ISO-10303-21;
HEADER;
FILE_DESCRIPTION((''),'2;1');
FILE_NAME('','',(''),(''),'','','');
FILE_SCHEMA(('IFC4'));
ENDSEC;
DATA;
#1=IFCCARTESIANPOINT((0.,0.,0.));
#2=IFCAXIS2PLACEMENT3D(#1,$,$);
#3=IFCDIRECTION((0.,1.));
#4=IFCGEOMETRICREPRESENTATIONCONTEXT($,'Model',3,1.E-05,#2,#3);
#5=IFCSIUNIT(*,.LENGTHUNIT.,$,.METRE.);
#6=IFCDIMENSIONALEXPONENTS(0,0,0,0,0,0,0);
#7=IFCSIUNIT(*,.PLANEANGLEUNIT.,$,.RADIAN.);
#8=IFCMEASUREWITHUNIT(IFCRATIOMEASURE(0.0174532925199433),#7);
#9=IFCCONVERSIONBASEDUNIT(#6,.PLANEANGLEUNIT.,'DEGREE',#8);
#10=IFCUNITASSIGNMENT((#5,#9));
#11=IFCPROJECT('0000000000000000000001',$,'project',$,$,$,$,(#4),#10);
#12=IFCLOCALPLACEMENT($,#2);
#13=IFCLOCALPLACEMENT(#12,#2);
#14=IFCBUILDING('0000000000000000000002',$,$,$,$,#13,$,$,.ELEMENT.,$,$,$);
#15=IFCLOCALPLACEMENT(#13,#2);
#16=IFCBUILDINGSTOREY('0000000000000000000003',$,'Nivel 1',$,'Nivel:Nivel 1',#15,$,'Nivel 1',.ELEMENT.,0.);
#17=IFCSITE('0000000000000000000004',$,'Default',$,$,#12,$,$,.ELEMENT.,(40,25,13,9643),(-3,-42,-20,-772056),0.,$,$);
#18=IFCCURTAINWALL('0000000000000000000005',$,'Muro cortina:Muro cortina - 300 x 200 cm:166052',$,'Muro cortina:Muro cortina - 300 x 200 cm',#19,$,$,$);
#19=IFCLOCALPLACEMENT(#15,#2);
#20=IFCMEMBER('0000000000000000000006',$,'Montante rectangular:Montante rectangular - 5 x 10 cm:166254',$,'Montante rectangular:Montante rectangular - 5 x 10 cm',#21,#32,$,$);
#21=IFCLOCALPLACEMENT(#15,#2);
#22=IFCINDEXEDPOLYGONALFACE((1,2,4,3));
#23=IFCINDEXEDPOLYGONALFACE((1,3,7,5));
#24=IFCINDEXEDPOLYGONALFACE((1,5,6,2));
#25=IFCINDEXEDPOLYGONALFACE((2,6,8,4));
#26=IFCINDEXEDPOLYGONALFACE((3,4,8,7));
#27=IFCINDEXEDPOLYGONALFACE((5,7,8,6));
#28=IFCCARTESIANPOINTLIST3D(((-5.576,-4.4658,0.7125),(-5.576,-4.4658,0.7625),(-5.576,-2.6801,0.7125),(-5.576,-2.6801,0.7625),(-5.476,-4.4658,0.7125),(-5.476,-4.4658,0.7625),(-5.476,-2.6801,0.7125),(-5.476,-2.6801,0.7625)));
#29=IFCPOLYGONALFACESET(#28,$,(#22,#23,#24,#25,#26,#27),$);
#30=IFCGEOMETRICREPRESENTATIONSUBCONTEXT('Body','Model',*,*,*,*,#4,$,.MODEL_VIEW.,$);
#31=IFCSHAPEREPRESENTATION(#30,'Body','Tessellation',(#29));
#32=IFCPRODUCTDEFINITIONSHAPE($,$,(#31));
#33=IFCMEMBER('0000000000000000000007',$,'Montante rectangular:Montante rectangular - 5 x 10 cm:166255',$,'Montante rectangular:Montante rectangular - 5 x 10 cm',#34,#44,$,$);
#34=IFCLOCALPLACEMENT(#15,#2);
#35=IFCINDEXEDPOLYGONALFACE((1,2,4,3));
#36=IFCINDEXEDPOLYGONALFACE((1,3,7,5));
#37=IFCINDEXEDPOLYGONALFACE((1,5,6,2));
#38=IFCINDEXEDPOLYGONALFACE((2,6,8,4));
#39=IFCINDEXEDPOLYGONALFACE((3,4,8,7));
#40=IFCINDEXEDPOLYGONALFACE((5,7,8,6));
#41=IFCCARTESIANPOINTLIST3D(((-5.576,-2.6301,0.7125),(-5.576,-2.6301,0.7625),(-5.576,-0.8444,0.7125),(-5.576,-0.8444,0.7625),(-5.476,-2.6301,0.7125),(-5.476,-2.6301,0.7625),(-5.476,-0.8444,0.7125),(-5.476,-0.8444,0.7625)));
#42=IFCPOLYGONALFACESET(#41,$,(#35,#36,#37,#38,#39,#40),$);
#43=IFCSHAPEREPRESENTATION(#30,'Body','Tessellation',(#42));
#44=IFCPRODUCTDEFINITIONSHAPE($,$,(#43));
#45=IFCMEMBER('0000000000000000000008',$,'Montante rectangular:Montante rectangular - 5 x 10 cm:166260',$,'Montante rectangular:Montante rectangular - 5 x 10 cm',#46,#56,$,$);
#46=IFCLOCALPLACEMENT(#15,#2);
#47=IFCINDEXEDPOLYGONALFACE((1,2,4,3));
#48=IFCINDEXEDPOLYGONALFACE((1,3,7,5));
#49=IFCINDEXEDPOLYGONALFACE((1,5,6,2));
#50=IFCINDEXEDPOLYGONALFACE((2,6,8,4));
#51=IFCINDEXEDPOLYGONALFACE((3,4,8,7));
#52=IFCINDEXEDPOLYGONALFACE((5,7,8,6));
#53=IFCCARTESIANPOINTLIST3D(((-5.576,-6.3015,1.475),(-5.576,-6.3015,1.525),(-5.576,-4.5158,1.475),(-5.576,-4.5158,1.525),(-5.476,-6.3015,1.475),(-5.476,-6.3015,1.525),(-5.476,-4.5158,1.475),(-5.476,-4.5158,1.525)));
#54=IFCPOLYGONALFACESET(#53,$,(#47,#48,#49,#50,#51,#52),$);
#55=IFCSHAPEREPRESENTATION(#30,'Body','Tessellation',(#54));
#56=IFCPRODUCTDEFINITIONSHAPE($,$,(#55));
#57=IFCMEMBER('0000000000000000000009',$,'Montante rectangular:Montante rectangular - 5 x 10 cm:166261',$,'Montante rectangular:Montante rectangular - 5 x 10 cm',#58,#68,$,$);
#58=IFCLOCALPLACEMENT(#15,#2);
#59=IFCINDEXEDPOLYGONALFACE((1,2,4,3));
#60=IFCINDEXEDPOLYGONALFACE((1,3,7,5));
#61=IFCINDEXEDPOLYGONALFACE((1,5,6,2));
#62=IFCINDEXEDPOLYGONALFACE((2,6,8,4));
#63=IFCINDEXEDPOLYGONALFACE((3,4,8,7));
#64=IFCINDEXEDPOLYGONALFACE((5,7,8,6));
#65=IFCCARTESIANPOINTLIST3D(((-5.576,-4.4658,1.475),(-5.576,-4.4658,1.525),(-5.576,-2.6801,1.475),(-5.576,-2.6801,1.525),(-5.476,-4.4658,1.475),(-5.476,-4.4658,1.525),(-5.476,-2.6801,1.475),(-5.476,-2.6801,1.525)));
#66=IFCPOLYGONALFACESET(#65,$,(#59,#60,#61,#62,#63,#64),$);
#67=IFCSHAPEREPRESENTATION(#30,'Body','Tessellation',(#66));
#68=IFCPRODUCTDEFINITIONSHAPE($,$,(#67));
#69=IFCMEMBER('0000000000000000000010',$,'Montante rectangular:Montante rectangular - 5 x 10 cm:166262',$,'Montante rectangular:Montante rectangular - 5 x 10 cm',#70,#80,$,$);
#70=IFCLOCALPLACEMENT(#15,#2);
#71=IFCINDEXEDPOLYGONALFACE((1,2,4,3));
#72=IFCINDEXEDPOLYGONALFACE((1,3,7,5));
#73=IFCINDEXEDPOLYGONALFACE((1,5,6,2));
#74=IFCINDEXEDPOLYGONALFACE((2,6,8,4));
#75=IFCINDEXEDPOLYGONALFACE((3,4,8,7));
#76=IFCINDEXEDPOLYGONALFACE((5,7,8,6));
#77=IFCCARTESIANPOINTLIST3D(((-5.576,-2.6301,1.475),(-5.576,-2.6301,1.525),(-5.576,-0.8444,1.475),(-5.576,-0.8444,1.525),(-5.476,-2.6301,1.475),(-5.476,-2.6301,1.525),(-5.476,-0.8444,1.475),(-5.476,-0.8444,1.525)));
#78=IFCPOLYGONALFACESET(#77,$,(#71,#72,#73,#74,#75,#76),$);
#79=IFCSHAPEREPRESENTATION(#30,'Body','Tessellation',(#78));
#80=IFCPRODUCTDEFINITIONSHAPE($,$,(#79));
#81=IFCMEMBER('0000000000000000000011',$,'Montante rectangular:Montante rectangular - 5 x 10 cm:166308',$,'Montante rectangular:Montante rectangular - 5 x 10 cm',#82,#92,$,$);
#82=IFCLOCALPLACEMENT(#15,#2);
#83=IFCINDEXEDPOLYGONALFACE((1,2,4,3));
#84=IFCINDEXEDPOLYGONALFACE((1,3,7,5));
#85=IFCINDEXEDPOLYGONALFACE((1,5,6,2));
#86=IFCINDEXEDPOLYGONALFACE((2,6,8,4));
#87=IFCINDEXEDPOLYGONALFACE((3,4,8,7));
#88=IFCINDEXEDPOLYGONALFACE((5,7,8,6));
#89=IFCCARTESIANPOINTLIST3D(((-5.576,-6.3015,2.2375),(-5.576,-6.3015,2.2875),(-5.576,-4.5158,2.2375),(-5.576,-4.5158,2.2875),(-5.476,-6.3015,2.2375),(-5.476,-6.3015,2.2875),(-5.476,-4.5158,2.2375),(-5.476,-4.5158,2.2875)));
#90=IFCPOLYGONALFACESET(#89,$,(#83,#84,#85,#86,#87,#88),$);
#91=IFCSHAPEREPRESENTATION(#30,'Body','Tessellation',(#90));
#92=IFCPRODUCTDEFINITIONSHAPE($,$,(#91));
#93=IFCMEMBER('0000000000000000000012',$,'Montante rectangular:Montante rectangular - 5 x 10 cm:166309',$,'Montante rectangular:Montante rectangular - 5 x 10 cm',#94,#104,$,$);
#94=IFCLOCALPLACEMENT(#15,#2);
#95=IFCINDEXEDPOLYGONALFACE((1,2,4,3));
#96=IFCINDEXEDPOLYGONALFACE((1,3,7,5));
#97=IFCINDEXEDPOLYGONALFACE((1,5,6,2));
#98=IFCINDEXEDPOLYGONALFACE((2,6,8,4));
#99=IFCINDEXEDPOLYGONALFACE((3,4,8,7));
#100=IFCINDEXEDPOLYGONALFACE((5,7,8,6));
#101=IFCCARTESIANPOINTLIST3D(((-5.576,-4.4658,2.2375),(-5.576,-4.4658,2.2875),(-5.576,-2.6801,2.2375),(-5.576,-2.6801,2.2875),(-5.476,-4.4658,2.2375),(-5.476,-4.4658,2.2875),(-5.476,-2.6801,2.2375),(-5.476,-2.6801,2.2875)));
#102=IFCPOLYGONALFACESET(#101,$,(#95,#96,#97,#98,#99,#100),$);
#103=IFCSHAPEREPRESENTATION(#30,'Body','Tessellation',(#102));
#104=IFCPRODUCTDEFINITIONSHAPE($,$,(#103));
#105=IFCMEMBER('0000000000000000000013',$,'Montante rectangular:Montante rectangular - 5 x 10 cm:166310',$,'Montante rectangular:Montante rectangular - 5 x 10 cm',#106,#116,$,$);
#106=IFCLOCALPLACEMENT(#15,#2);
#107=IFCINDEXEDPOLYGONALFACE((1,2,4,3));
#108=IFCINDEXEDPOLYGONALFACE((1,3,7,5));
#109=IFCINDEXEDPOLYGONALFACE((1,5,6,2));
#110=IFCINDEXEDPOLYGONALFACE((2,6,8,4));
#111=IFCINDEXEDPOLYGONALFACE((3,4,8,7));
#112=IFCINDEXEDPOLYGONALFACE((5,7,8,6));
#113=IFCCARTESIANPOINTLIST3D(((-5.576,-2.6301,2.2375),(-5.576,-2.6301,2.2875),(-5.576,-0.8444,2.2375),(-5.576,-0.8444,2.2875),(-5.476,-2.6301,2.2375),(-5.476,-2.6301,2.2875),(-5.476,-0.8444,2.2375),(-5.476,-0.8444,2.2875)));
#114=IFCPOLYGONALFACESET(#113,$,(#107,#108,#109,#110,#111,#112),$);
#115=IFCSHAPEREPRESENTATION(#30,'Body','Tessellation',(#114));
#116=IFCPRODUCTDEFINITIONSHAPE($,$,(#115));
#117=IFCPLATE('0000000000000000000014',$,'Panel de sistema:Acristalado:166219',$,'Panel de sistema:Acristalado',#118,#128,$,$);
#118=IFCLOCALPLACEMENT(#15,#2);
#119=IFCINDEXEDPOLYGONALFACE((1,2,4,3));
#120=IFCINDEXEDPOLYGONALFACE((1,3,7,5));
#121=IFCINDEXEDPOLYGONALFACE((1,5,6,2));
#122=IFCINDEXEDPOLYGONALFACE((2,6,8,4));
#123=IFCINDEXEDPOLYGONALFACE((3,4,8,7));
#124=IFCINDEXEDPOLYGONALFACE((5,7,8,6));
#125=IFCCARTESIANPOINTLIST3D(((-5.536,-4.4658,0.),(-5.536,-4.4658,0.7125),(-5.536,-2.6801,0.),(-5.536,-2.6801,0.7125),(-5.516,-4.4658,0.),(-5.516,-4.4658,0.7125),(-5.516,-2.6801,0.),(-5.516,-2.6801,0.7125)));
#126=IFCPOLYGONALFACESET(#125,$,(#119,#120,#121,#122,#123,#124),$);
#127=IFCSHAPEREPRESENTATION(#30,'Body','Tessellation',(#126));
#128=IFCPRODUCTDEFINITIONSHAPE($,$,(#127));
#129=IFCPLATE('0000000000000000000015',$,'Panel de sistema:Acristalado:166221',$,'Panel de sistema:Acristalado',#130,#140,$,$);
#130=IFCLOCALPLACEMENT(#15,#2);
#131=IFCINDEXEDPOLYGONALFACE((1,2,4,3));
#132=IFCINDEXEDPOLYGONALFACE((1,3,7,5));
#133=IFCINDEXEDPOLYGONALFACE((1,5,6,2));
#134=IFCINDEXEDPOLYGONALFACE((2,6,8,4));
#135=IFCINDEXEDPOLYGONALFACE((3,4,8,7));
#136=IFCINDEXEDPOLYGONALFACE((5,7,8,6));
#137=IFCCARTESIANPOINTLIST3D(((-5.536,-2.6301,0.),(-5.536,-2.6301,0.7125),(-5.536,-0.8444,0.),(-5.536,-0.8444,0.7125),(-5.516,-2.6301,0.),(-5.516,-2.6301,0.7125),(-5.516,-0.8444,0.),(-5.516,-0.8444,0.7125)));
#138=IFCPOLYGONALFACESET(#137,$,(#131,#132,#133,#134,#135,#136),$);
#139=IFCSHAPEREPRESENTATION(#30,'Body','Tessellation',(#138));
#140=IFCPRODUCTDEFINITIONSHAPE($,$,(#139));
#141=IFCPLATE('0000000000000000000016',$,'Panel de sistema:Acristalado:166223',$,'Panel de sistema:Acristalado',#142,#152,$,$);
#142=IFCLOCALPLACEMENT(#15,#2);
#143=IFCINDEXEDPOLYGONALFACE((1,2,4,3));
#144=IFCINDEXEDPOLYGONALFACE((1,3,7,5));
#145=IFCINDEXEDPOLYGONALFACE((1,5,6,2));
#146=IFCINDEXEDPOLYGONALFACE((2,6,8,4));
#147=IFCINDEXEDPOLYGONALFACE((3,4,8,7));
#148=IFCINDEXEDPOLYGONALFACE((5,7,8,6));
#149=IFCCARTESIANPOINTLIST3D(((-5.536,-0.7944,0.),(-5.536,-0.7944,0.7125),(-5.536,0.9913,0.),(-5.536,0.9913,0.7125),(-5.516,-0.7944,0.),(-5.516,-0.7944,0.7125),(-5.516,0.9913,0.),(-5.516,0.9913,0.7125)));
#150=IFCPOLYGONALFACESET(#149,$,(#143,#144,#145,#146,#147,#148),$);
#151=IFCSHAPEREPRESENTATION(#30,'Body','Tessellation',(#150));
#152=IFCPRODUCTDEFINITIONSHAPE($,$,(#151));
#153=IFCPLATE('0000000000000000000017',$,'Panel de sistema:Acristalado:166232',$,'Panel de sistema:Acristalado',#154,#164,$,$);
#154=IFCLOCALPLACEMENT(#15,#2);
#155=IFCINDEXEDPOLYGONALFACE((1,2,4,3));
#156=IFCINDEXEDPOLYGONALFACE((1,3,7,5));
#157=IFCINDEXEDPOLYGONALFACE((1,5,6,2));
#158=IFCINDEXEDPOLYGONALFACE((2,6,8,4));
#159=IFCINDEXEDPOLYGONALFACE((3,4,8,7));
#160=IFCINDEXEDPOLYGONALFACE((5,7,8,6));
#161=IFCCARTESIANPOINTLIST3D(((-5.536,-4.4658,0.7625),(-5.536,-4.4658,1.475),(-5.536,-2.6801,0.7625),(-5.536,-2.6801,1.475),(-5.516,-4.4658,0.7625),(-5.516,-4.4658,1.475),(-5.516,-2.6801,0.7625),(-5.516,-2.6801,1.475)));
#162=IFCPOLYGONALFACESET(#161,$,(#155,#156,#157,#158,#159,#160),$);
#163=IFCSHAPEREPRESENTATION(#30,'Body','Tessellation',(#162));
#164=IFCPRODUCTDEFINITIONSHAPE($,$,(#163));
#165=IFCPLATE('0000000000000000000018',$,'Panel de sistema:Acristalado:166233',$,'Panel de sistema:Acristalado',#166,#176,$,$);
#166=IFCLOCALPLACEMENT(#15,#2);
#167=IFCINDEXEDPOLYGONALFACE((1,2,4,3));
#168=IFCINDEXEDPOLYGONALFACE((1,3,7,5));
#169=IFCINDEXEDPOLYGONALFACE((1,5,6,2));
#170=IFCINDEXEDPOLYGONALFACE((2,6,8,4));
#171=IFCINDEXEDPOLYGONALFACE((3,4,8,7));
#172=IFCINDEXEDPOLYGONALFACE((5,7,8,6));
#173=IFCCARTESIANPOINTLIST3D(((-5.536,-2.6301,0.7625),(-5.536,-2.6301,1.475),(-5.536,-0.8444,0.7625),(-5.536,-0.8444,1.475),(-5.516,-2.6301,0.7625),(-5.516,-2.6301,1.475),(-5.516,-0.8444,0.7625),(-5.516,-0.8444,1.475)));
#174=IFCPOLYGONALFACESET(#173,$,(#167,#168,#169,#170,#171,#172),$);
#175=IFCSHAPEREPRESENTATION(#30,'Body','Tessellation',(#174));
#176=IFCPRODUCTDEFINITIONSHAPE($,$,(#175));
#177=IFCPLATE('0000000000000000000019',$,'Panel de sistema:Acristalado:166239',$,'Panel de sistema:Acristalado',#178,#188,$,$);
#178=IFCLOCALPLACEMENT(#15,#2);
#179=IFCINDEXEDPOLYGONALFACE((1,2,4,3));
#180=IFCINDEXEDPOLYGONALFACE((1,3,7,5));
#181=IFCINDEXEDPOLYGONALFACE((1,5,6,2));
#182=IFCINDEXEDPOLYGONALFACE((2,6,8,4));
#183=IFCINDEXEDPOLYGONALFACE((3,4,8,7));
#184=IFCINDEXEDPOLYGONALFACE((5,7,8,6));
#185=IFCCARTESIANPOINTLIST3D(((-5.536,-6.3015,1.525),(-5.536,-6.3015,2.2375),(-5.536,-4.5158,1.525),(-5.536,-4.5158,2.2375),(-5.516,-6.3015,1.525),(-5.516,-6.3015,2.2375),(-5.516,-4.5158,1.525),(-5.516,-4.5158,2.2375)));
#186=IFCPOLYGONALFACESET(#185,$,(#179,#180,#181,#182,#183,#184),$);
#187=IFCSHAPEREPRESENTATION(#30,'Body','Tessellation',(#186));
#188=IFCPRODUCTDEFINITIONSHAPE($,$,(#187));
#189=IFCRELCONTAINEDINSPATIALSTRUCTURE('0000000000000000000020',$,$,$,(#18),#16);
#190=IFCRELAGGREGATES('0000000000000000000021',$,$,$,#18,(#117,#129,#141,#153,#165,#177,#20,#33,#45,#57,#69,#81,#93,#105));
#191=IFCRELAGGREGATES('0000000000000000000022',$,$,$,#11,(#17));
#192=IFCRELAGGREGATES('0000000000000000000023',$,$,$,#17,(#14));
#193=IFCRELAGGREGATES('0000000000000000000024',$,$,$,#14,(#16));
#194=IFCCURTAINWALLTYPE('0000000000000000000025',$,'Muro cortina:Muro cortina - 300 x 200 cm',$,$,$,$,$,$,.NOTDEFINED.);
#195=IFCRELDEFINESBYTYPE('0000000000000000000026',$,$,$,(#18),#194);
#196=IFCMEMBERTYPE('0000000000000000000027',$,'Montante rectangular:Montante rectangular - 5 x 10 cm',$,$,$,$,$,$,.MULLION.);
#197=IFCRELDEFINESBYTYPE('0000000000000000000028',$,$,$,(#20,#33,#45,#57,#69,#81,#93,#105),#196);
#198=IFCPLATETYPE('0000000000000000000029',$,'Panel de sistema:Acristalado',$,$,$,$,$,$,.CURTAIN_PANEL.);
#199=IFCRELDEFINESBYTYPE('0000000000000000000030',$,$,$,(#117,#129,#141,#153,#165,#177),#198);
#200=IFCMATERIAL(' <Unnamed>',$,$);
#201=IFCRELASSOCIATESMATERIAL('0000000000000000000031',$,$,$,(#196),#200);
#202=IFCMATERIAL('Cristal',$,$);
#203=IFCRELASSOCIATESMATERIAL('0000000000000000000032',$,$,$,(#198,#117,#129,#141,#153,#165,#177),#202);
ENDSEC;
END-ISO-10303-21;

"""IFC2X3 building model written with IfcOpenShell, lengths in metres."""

from ifc_helpers import new_model, entity, si_unit, converted_unit, direction, frame, origin, origin_2d_with_axis, place, context, subcontext, project, spatial, rectangle, extrude, source, transform, mapped, material, type_object, type_shapes, element, aggregate, save


model = new_model("IFC2X3")

# Units and contexts
model_context = context("Model", 3, precision=1e-05, world=origin(), true_north=direction((0.0, 1.0)))
body_context = subcontext(model_context, "Body", "Model", "MODEL_VIEW")
ifc_project = project(units=[si_unit("LENGTHUNIT", "METRE"), converted_unit("PLANEANGLEUNIT", "DEGREE", entity("IfcRatioMeasure", 0.0174532925199433), si_unit("PLANEANGLEUNIT", "RADIAN"), dimensions=[0, 0, 0, 0, 0, 0, 0])], contexts=[model_context])

# Site, building, storey
site_placement = place(None, origin())
site = spatial("IfcSite", under=ifc_project, at=site_placement, Name="Default", CompositionType="ELEMENT", RefLatitude=(40, 25, 13, 9643), RefLongitude=(-3, -42, -20, -772056), RefElevation=0.0)
building_placement = place(site_placement, origin())
building = spatial("IfcBuilding", under=site, at=building_placement, CompositionType="ELEMENT")
storey_placement = place(building_placement, origin())
storey = spatial("IfcBuildingStorey", under=building, at=storey_placement, Name="Nivel 1", ObjectType="Nivel:Nivel 1", LongName="Nivel 1", CompositionType="ELEMENT", Elevation=0.0)

# Curtain wall, members, plates
curtain_wall_type = type_object("IfcCurtainWallType", Name="Muro cortina:Muro cortina - 300 x 200 cm", PredefinedType="NOTDEFINED")
curtain_wall_placement = place(storey_placement, origin())
curtain_wall = element("IfcCurtainWall", 1, at=curtain_wall_placement, inside=storey, type_object=curtain_wall_type, Name="Muro cortina:Muro cortina - 300 x 200 cm:166052", ObjectType="Muro cortina:Muro cortina - 300 x 200 cm")
ifc_material_1 = material(Name=" <Unnamed>")
member_type_1 = type_object("IfcMemberType", Name="Montante rectangular:Montante rectangular - 5 x 10 cm", PredefinedType="MULLION", material=ifc_material_1)
shared_shape_1 = source(origin(), body_context, "Body", "SweptSolid", [
    extrude(rectangle(XDim=0.1, YDim=0.05, at=origin_2d_with_axis()), frame((0.0, 0.0, -1.7857), z_axis=(0.0, 0.0, 1.0), x_axis=(0.0, -1.0, 0.0)), (0.0, 0.0, 1.0), 1.7857),
])
type_shapes(member_type_1, [shared_shape_1])
member_1_placement = place(storey_placement, frame((-5.526, -2.6801, 0.7375), z_axis=(0.0, 1.0, 0.0), x_axis=(0.0, 0.0, 1.0)))
member_1 = element("IfcMember", 2, at=member_1_placement, type_object=member_type_1, Name="Montante rectangular:Montante rectangular - 5 x 10 cm:166254", ObjectType="Montante rectangular:Montante rectangular - 5 x 10 cm", context=body_context, shape_type="MappedRepresentation", body=[
    mapped(shared_shape_1, transform((0.0, 0.0, 0.0), scale=1.0)),
])
member_2_placement = place(storey_placement, frame((-5.526, -0.8444, 0.7375), z_axis=(0.0, 1.0, 0.0), x_axis=(0.0, 0.0, 1.0)))
member_2 = element("IfcMember", 3, at=member_2_placement, type_object=member_type_1, Name="Montante rectangular:Montante rectangular - 5 x 10 cm:166255", ObjectType="Montante rectangular:Montante rectangular - 5 x 10 cm", context=body_context, shape_type="MappedRepresentation", body=[
    mapped(shared_shape_1, transform((0.0, 0.0, 0.0), scale=1.0)),
])
member_3_placement = place(storey_placement, frame((-5.526, -4.5158, 1.5), z_axis=(0.0, 1.0, 0.0), x_axis=(0.0, 0.0, 1.0)))
member_3 = element("IfcMember", 4, at=member_3_placement, type_object=member_type_1, Name="Montante rectangular:Montante rectangular - 5 x 10 cm:166260", ObjectType="Montante rectangular:Montante rectangular - 5 x 10 cm", context=body_context, shape_type="MappedRepresentation", body=[
    mapped(shared_shape_1, transform((0.0, 0.0, 0.0), scale=1.0)),
])
member_4_placement = place(storey_placement, frame((-5.526, -2.6801, 1.5), z_axis=(0.0, 1.0, 0.0), x_axis=(0.0, 0.0, 1.0)))
member_4 = element("IfcMember", 5, at=member_4_placement, type_object=member_type_1, Name="Montante rectangular:Montante rectangular - 5 x 10 cm:166261", ObjectType="Montante rectangular:Montante rectangular - 5 x 10 cm", context=body_context, shape_type="MappedRepresentation", body=[
    mapped(shared_shape_1, transform((0.0, 0.0, 0.0), scale=1.0)),
])
member_5_placement = place(storey_placement, frame((-5.526, -0.8444, 1.5), z_axis=(0.0, 1.0, 0.0), x_axis=(0.0, 0.0, 1.0)))
member_5 = element("IfcMember", 6, at=member_5_placement, type_object=member_type_1, Name="Montante rectangular:Montante rectangular - 5 x 10 cm:166262", ObjectType="Montante rectangular:Montante rectangular - 5 x 10 cm", context=body_context, shape_type="MappedRepresentation", body=[
    mapped(shared_shape_1, transform((0.0, 0.0, 0.0), scale=1.0)),
])
member_6_placement = place(storey_placement, frame((-5.526, -4.5158, 2.2625), z_axis=(0.0, 1.0, 0.0), x_axis=(0.0, 0.0, 1.0)))
member_6 = element("IfcMember", 7, at=member_6_placement, type_object=member_type_1, Name="Montante rectangular:Montante rectangular - 5 x 10 cm:166308", ObjectType="Montante rectangular:Montante rectangular - 5 x 10 cm", context=body_context, shape_type="MappedRepresentation", body=[
    mapped(shared_shape_1, transform((0.0, 0.0, 0.0), scale=1.0)),
])
member_7_placement = place(storey_placement, frame((-5.526, -2.6801, 2.2625), z_axis=(0.0, 1.0, 0.0), x_axis=(0.0, 0.0, 1.0)))
member_7 = element("IfcMember", 8, at=member_7_placement, type_object=member_type_1, Name="Montante rectangular:Montante rectangular - 5 x 10 cm:166309", ObjectType="Montante rectangular:Montante rectangular - 5 x 10 cm", context=body_context, shape_type="MappedRepresentation", body=[
    mapped(shared_shape_1, transform((0.0, 0.0, 0.0), scale=1.0)),
])
member_8_placement = place(storey_placement, frame((-5.526, -0.8444, 2.2625), z_axis=(0.0, 1.0, 0.0), x_axis=(0.0, 0.0, 1.0)))
member_8 = element("IfcMember", 9, at=member_8_placement, type_object=member_type_1, Name="Montante rectangular:Montante rectangular - 5 x 10 cm:166310", ObjectType="Montante rectangular:Montante rectangular - 5 x 10 cm", context=body_context, shape_type="MappedRepresentation", body=[
    mapped(shared_shape_1, transform((0.0, 0.0, 0.0), scale=1.0)),
])
ifc_material_2 = material(Name="Cristal")
plate_type = type_object("IfcPlateType", Name="Panel de sistema:Acristalado", PredefinedType="CURTAIN_PANEL", material=ifc_material_2)
shared_shape_2 = source(origin(), body_context, "Body", "SweptSolid", [
    extrude(rectangle(XDim=0.02, YDim=1.7857, at=origin_2d_with_axis()), frame((0.0, 0.0, 0.0), z_axis=(0.0, 0.0, 1.0), x_axis=(0.0, 1.0, 0.0)), (0.0, 0.0, 1.0), 0.7125),
])
type_shapes(plate_type, [shared_shape_2])
plate_1_placement = place(curtain_wall_placement, frame((-5.526, -3.573, 0.0), z_axis=(0.0, 0.0, 1.0), x_axis=(0.0, 1.0, 0.0)))
plate_1 = element("IfcPlate", 10, at=plate_1_placement, type_object=plate_type, material=ifc_material_2, Name="Panel de sistema:Acristalado:166219", ObjectType="Panel de sistema:Acristalado", context=body_context, shape_type="MappedRepresentation", body=[
    mapped(shared_shape_2, transform((0.0, 0.0, 0.0), scale=1.0)),
])
plate_2_placement = place(curtain_wall_placement, frame((-5.526, -1.7373, 0.0), z_axis=(0.0, 0.0, 1.0), x_axis=(0.0, 1.0, 0.0)))
plate_2 = element("IfcPlate", 11, at=plate_2_placement, type_object=plate_type, material=ifc_material_2, Name="Panel de sistema:Acristalado:166221", ObjectType="Panel de sistema:Acristalado", context=body_context, shape_type="MappedRepresentation", body=[
    mapped(shared_shape_2, transform((0.0, 0.0, 0.0), scale=1.0)),
])
plate_3_placement = place(curtain_wall_placement, frame((-5.526, 0.0985, 0.0), z_axis=(0.0, 0.0, 1.0), x_axis=(0.0, 1.0, 0.0)))
plate_3 = element("IfcPlate", 12, at=plate_3_placement, type_object=plate_type, material=ifc_material_2, Name="Panel de sistema:Acristalado:166223", ObjectType="Panel de sistema:Acristalado", context=body_context, shape_type="MappedRepresentation", body=[
    mapped(shared_shape_2, transform((0.0, 0.0, 0.0), scale=1.0)),
])
plate_4_placement = place(curtain_wall_placement, frame((-5.526, -3.573, 0.7625), z_axis=(0.0, 0.0, 1.0), x_axis=(0.0, 1.0, 0.0)))
plate_4 = element("IfcPlate", 13, at=plate_4_placement, type_object=plate_type, material=ifc_material_2, Name="Panel de sistema:Acristalado:166232", ObjectType="Panel de sistema:Acristalado", context=body_context, shape_type="MappedRepresentation", body=[
    mapped(shared_shape_2, transform((0.0, 0.0, 0.0), scale=1.0)),
])
plate_5_placement = place(curtain_wall_placement, frame((-5.526, -1.7373, 0.7625), z_axis=(0.0, 0.0, 1.0), x_axis=(0.0, 1.0, 0.0)))
plate_5 = element("IfcPlate", 14, at=plate_5_placement, type_object=plate_type, material=ifc_material_2, Name="Panel de sistema:Acristalado:166233", ObjectType="Panel de sistema:Acristalado", context=body_context, shape_type="MappedRepresentation", body=[
    mapped(shared_shape_2, transform((0.0, 0.0, 0.0), scale=1.0)),
])
plate_6_placement = place(curtain_wall_placement, frame((-5.526, -5.4087, 1.525), z_axis=(0.0, 0.0, 1.0), x_axis=(0.0, 1.0, 0.0)))
plate_6 = element("IfcPlate", 15, at=plate_6_placement, type_object=plate_type, material=ifc_material_2, Name="Panel de sistema:Acristalado:166239", ObjectType="Panel de sistema:Acristalado", context=body_context, shape_type="MappedRepresentation", body=[
    mapped(shared_shape_2, transform((0.0, 0.0, 0.0), scale=1.0)),
])
aggregate(curtain_wall, [plate_1, plate_2, plate_3, plate_4, plate_5, plate_6, member_1, member_2, member_3, member_4, member_5, member_6, member_7, member_8])

save(model, "model.ifc")
